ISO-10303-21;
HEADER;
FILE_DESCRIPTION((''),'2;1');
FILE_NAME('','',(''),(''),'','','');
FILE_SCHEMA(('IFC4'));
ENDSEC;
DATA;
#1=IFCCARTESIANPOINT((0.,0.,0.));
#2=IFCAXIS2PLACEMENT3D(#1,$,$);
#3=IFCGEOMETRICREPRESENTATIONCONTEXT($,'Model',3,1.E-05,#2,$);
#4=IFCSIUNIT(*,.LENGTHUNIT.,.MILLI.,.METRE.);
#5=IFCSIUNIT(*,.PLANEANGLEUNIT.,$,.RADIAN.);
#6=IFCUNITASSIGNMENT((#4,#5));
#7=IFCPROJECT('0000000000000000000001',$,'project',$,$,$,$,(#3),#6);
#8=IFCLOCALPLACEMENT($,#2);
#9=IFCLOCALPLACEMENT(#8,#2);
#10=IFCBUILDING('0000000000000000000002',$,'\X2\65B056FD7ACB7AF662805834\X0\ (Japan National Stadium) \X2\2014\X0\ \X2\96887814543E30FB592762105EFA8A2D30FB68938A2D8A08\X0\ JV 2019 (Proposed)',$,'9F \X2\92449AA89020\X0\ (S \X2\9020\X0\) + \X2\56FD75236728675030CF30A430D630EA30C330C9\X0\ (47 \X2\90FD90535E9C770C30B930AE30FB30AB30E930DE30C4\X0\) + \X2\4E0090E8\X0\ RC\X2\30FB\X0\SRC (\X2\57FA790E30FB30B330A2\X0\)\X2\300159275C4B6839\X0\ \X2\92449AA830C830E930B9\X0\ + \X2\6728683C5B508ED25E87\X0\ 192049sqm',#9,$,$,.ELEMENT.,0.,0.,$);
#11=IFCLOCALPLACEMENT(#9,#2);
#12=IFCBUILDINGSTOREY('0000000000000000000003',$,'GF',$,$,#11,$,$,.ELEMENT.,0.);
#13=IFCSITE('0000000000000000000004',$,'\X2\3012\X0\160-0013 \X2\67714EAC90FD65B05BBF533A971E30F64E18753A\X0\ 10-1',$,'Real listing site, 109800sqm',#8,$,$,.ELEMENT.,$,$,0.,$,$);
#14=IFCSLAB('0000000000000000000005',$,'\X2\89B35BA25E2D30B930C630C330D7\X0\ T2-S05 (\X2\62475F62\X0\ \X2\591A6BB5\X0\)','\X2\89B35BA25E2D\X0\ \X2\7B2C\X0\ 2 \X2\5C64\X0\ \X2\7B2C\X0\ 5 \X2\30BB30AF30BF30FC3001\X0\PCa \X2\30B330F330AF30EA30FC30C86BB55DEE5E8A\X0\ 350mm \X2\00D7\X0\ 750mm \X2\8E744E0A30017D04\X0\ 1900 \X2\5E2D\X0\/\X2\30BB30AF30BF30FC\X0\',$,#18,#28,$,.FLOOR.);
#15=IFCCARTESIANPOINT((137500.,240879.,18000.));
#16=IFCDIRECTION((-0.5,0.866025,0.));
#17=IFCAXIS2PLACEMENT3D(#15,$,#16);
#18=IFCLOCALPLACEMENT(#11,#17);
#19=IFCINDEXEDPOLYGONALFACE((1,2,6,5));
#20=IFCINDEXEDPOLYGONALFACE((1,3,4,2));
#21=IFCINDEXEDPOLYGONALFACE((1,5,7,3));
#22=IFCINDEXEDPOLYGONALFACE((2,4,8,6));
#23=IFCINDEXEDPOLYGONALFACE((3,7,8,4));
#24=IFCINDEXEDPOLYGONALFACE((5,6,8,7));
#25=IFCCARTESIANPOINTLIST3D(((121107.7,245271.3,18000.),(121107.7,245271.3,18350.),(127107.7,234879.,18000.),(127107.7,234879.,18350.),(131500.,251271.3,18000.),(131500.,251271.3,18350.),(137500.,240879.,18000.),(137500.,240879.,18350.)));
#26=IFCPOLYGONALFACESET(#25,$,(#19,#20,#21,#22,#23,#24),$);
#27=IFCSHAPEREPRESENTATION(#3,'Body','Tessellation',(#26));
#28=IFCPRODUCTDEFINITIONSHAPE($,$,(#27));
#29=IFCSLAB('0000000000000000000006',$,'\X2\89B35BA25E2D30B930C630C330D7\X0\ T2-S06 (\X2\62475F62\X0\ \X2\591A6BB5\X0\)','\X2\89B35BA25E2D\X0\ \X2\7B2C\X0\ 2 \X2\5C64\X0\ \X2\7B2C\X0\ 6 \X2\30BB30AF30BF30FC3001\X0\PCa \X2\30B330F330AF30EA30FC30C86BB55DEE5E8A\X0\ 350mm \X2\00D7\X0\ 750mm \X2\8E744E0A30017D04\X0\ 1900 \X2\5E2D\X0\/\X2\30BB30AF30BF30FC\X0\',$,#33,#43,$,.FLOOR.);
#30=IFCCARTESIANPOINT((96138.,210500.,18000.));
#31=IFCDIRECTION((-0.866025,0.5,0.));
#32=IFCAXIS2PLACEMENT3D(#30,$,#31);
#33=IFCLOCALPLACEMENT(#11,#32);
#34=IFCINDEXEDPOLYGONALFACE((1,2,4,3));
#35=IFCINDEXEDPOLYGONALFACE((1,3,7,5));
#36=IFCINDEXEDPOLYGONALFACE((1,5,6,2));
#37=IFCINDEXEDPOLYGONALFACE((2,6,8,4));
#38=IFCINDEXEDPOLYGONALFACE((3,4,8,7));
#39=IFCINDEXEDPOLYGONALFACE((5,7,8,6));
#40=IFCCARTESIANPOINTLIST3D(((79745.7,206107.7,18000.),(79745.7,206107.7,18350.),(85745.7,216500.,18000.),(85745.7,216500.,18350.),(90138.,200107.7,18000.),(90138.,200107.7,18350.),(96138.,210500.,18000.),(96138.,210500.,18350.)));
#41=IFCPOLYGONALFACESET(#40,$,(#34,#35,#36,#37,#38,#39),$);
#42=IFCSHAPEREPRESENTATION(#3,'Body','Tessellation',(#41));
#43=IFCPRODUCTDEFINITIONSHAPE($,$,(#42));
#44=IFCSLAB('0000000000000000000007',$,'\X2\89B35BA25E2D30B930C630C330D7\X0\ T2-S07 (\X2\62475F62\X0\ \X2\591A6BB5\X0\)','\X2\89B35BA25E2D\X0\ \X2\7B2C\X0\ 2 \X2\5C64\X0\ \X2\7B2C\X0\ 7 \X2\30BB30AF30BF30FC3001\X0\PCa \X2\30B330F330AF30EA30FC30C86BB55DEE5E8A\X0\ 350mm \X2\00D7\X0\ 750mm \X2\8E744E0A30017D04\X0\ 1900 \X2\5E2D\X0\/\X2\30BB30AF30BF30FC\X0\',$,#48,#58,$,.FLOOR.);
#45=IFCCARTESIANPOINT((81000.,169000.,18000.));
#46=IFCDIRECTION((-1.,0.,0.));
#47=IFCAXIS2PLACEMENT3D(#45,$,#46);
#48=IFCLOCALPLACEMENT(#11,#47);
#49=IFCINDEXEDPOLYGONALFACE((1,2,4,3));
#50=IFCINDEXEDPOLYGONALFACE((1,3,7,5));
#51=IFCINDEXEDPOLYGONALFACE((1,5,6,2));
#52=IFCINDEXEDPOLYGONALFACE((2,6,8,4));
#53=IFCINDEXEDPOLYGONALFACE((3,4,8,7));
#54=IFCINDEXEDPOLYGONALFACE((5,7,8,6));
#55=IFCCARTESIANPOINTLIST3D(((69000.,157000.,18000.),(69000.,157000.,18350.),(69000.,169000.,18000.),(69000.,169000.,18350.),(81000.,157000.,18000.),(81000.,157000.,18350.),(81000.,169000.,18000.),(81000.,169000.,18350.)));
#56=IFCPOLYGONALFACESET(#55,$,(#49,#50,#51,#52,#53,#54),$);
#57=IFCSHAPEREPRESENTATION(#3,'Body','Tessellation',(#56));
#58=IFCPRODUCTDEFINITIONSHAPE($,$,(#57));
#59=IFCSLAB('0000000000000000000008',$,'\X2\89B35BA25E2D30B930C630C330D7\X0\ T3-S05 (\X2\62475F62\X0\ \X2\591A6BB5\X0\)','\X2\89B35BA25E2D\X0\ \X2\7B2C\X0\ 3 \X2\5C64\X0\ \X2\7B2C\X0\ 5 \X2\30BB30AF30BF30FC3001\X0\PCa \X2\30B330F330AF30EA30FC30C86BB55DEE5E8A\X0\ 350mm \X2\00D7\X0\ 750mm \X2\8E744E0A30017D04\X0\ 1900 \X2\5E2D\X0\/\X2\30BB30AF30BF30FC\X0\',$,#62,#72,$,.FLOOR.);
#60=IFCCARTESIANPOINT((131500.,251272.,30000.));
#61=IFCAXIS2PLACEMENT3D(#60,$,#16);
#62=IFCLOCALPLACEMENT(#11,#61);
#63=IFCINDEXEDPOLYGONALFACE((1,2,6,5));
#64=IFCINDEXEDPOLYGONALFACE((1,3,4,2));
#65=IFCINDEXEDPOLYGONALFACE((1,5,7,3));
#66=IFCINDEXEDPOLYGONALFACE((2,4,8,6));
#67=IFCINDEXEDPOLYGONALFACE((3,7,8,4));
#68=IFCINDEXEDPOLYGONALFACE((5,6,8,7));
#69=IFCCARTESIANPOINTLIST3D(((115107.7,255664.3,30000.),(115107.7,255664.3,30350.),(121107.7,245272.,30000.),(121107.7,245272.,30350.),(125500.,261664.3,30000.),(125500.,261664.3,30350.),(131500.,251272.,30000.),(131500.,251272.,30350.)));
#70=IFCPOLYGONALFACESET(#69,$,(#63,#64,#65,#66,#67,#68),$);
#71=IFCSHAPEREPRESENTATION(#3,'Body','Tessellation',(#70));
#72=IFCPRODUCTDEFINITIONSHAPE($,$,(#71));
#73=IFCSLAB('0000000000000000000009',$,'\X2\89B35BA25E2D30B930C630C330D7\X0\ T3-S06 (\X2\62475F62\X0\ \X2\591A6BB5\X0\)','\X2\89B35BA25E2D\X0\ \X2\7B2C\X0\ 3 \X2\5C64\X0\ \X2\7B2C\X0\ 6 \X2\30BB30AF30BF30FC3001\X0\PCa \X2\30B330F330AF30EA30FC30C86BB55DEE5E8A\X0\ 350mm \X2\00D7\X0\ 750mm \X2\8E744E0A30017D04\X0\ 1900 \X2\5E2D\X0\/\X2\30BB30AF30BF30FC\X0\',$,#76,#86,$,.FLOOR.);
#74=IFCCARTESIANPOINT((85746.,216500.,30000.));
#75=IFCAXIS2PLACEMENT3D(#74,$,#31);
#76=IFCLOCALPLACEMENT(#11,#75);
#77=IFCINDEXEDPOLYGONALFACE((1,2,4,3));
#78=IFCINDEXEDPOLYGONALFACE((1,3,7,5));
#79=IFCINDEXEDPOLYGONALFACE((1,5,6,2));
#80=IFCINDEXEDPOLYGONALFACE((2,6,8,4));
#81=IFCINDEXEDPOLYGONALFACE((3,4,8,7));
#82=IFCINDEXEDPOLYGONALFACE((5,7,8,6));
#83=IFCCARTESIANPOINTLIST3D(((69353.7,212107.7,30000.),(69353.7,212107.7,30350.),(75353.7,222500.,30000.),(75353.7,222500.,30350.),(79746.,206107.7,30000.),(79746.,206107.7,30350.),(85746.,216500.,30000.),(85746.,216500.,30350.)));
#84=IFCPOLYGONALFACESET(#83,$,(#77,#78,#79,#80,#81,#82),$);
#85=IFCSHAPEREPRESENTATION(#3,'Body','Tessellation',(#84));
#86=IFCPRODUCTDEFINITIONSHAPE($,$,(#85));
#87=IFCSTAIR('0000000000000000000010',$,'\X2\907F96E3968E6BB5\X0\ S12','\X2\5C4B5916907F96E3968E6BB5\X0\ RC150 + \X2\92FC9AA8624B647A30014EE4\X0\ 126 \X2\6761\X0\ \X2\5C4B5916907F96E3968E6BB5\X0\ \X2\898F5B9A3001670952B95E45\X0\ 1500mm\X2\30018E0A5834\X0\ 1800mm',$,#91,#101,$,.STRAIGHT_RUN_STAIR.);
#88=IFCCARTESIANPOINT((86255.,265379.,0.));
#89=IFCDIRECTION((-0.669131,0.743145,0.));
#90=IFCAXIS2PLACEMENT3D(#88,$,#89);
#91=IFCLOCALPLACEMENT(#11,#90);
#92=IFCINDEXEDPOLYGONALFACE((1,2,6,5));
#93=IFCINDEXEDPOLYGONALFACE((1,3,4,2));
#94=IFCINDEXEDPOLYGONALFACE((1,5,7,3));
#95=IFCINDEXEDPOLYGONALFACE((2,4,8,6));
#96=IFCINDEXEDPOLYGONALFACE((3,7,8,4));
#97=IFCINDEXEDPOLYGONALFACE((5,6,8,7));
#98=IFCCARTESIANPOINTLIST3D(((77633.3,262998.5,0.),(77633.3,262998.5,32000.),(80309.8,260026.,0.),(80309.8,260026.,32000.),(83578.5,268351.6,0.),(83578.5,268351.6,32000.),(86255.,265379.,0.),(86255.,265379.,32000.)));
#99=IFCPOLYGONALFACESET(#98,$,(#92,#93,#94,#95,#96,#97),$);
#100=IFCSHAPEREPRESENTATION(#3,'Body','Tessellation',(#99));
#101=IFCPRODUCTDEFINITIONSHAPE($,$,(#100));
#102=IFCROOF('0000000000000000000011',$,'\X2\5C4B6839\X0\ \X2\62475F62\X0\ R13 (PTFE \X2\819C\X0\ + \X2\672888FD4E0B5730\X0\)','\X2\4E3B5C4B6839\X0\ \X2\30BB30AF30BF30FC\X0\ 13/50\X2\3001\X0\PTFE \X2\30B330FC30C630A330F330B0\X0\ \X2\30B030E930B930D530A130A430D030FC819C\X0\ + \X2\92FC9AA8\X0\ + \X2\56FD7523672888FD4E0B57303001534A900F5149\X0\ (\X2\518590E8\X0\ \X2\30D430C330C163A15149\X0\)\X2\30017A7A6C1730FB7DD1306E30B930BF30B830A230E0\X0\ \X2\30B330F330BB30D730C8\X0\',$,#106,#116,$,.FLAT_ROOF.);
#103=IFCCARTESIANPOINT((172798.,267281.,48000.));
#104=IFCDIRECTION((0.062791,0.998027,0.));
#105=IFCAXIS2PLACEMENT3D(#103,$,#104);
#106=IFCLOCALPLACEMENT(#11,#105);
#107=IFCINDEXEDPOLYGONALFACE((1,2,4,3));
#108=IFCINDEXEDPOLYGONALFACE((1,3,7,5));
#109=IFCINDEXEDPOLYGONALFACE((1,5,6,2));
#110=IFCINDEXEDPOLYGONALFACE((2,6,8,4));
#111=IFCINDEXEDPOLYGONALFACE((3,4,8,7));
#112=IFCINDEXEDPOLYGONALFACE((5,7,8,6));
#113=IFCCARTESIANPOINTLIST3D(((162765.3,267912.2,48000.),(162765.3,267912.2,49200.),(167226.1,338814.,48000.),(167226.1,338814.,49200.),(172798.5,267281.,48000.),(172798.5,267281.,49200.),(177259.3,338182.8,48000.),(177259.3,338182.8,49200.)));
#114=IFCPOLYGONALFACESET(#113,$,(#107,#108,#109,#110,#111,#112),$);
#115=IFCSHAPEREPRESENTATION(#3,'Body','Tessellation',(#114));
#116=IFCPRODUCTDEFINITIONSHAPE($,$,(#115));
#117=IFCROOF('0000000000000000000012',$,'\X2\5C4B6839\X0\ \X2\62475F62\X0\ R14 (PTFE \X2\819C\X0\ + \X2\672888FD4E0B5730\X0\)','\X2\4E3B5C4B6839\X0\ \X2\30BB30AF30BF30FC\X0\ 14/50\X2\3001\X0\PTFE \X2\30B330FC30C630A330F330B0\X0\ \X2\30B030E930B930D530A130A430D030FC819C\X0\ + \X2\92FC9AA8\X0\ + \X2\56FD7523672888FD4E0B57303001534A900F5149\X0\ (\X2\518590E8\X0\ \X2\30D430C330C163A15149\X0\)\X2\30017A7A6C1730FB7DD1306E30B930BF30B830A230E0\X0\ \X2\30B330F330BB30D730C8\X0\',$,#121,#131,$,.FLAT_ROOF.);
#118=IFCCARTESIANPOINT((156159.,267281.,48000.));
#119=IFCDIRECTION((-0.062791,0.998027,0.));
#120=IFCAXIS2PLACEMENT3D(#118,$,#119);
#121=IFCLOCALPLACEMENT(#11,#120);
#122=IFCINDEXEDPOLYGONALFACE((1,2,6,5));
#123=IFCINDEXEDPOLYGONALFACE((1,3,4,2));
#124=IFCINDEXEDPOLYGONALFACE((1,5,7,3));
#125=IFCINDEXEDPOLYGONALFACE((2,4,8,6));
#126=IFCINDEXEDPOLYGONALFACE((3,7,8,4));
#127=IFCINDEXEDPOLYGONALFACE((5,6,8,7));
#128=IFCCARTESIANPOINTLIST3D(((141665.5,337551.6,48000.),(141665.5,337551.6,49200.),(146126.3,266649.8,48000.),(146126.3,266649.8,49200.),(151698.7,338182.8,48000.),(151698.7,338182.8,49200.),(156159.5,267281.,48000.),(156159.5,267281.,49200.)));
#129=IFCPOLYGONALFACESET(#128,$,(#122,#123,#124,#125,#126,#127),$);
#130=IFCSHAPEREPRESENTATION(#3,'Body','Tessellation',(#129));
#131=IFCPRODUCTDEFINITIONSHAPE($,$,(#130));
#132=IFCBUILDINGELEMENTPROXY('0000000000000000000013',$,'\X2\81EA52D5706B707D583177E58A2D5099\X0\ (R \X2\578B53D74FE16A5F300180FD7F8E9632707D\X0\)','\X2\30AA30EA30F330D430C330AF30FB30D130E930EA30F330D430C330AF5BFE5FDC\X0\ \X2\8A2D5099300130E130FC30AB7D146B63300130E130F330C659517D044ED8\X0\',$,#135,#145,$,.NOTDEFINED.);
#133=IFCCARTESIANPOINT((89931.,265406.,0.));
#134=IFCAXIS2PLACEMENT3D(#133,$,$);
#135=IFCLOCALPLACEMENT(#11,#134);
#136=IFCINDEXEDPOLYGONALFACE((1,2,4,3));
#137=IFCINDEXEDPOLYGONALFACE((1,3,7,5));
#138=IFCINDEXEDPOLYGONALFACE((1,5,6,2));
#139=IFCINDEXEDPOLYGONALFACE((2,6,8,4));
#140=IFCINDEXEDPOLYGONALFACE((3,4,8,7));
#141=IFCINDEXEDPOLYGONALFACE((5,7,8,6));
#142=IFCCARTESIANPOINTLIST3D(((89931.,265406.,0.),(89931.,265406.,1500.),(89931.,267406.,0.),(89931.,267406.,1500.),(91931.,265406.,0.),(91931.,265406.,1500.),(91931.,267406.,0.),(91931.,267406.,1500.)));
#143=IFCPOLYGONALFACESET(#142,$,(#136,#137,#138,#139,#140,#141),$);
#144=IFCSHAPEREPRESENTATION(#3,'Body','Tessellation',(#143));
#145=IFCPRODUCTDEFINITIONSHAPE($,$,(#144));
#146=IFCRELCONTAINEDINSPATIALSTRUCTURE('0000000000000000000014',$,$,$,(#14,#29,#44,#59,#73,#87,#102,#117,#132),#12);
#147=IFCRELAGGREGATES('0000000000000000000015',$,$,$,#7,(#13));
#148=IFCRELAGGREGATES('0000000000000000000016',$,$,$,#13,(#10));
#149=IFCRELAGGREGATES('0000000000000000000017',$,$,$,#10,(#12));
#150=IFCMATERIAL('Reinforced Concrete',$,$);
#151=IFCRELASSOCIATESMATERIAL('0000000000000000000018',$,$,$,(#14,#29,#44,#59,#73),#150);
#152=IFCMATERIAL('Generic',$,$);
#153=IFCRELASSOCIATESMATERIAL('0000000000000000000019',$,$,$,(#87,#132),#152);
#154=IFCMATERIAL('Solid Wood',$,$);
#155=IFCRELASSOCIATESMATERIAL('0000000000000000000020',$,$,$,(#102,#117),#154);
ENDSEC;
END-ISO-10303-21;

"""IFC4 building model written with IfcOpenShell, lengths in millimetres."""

from ifc_helpers import new_model, si_unit, frame, frame_2d, origin, place, context, project, spatial, rectangle, extrude, material, element, save


model = new_model("IFC4")

# Units and contexts
model_context = context("Model", 3, precision=1e-05, world=origin())
ifc_project = project(units=[si_unit("LENGTHUNIT", "METRE", prefix="MILLI"), si_unit("PLANEANGLEUNIT", "RADIAN")], contexts=[model_context])

# Site, building, storey
site_placement = place(None, origin())
site = spatial("IfcSite", under=ifc_project, at=site_placement, Name="〒160-0013 東京都新宿区霞ヶ丘町 10-1", ObjectType="Real listing site, 109800sqm", CompositionType="ELEMENT", RefElevation=0.0)
building_placement = place(site_placement, origin())
building = spatial("IfcBuilding", under=site, at=building_placement, Name="新国立競技場 (Japan National Stadium) — 隈研吾・大成建設・梓設計 JV 2019 (Proposed)", ObjectType="9F 鉄骨造 (S 造) + 国産木材ハイブリッド (47 都道府県スギ・カラマツ) + 一部 RC・SRC (基礎・コア)、大屋根 鉄骨トラス + 木格子軒庇 192049sqm", CompositionType="ELEMENT", ElevationOfRefHeight=0.0, ElevationOfTerrain=0.0)
storey_placement = place(building_placement, origin())
storey = spatial("IfcBuildingStorey", under=building, at=storey_placement, Name="GF", CompositionType="ELEMENT", Elevation=0.0)

# Shared definitions
ifc_material_1 = material(Name="Reinforced Concrete")
ifc_material_2 = material(Name="Generic")

# Shared definitions
ifc_material_3 = material(Name="Solid Wood")

# Slabs
slab_1_placement = place(storey_placement, frame((137500.0, 240879.0, 18000.0), x_axis=(-0.5, 0.866025, 0.0)))
element("IfcSlab", 1, at=slab_1_placement, inside=storey, material=ifc_material_1, Name="観客席ステップ T2-S05 (扇形 多段)", Description="観客席 第 2 層 第 5 セクター、PCa コンクリート段差床 350mm × 750mm 蹴上、約 1900 席/セクター", PredefinedType="FLOOR", context=model_context, shape_type="SweptSolid", body=[
    extrude(rectangle(XDim=12000.0, YDim=12000.0, at=frame_2d((6000.0, 6000.0))), frame((137500.0, 240879.0, 18000.0), x_axis=(-0.5, 0.866025, 0.0)), (0.0, 0.0, 1.0), 350.0),
])
slab_2_placement = place(storey_placement, frame((96138.0, 210500.0, 18000.0), x_axis=(-0.866025, 0.5, 0.0)))
element("IfcSlab", 2, at=slab_2_placement, inside=storey, material=ifc_material_1, Name="観客席ステップ T2-S06 (扇形 多段)", Description="観客席 第 2 層 第 6 セクター、PCa コンクリート段差床 350mm × 750mm 蹴上、約 1900 席/セクター", PredefinedType="FLOOR", context=model_context, shape_type="SweptSolid", body=[
    extrude(rectangle(XDim=12000.0, YDim=12000.0, at=frame_2d((6000.0, 6000.0))), frame((96138.0, 210500.0, 18000.0), x_axis=(-0.866025, 0.5, 0.0)), (0.0, 0.0, 1.0), 350.0),
])
slab_3_placement = place(storey_placement, frame((81000.0, 169000.0, 18000.0), x_axis=(-1.0, 0.0, 0.0)))
element("IfcSlab", 3, at=slab_3_placement, inside=storey, material=ifc_material_1, Name="観客席ステップ T2-S07 (扇形 多段)", Description="観客席 第 2 層 第 7 セクター、PCa コンクリート段差床 350mm × 750mm 蹴上、約 1900 席/セクター", PredefinedType="FLOOR", context=model_context, shape_type="SweptSolid", body=[
    extrude(rectangle(XDim=12000.0, YDim=12000.0, at=frame_2d((6000.0, 6000.0))), frame((81000.0, 169000.0, 18000.0), x_axis=(-1.0, 0.0, 0.0)), (0.0, 0.0, 1.0), 350.0),
])
slab_4_placement = place(storey_placement, frame((131500.0, 251272.0, 30000.0), x_axis=(-0.5, 0.866025, 0.0)))
element("IfcSlab", 4, at=slab_4_placement, inside=storey, material=ifc_material_1, Name="観客席ステップ T3-S05 (扇形 多段)", Description="観客席 第 3 層 第 5 セクター、PCa コンクリート段差床 350mm × 750mm 蹴上、約 1900 席/セクター", PredefinedType="FLOOR", context=model_context, shape_type="SweptSolid", body=[
    extrude(rectangle(XDim=12000.0, YDim=12000.0, at=frame_2d((6000.0, 6000.0))), frame((131500.0, 251272.0, 30000.0), x_axis=(-0.5, 0.866025, 0.0)), (0.0, 0.0, 1.0), 350.0),
])
slab_5_placement = place(storey_placement, frame((85746.0, 216500.0, 30000.0), x_axis=(-0.866025, 0.5, 0.0)))
element("IfcSlab", 5, at=slab_5_placement, inside=storey, material=ifc_material_1, Name="観客席ステップ T3-S06 (扇形 多段)", Description="観客席 第 3 層 第 6 セクター、PCa コンクリート段差床 350mm × 750mm 蹴上、約 1900 席/セクター", PredefinedType="FLOOR", context=model_context, shape_type="SweptSolid", body=[
    extrude(rectangle(XDim=12000.0, YDim=12000.0, at=frame_2d((6000.0, 6000.0))), frame((85746.0, 216500.0, 30000.0), x_axis=(-0.866025, 0.5, 0.0)), (0.0, 0.0, 1.0), 350.0),
])

# Stair
stair_placement = place(storey_placement, frame((86255.0, 265379.0, 0.0), x_axis=(-0.669131, 0.743145, 0.0)))
element("IfcStair", 6, at=stair_placement, inside=storey, material=ifc_material_2, Name="避難階段 S12", Description="屋外避難階段 RC150 + 鋼骨手摺、令 126 条 屋外避難階段 規定、有効幅 1500mm、踊場 1800mm", PredefinedType="STRAIGHT_RUN_STAIR", context=model_context, shape_type="SweptSolid", body=[
    extrude(rectangle(XDim=4000.0, YDim=8000.0, at=frame_2d((2000.0, 4000.0))), frame((86255.0, 265379.0, 0.0), x_axis=(-0.669131, 0.743145, 0.0)), (0.0, 0.0, 1.0), 32000.0),
])

# Roofs
roof_1_placement = place(storey_placement, frame((172798.0, 267281.0, 48000.0), x_axis=(0.062791, 0.998027, 0.0)))
element("IfcRoof", 7, at=roof_1_placement, inside=storey, material=ifc_material_3, Name="屋根 扇形 R13 (PTFE 膜 + 木製下地)", Description="主屋根 セクター 13/50、PTFE コーティング グラスファイバー膜 + 鋼骨 + 国産木製下地、半透光 (内部 ピッチ採光)、空気・緑のスタジアム コンセプト", PredefinedType="FLAT_ROOF", context=model_context, shape_type="SweptSolid", body=[
    extrude(rectangle(XDim=71042.0, YDim=10053.0, at=frame_2d((35521.0, 5026.0))), frame((172798.0, 267281.0, 48000.0), x_axis=(0.062791, 0.998027, 0.0)), (0.0, 0.0, 1.0), 1200.0),
])
roof_2_placement = place(storey_placement, frame((156159.0, 267281.0, 48000.0), x_axis=(-0.062791, 0.998027, 0.0)))
element("IfcRoof", 8, at=roof_2_placement, inside=storey, material=ifc_material_3, Name="屋根 扇形 R14 (PTFE 膜 + 木製下地)", Description="主屋根 セクター 14/50、PTFE コーティング グラスファイバー膜 + 鋼骨 + 国産木製下地、半透光 (内部 ピッチ採光)、空気・緑のスタジアム コンセプト", PredefinedType="FLAT_ROOF", context=model_context, shape_type="SweptSolid", body=[
    extrude(rectangle(XDim=71042.0, YDim=10053.0, at=frame_2d((35521.0, 5026.0))), frame((156159.0, 267281.0, 48000.0), x_axis=(-0.062791, 0.998027, 0.0)), (0.0, 0.0, 1.0), 1200.0),
])

# Building element proxy
proxy_placement = place(storey_placement, frame((89931.0, 265406.0, 0.0)))
element("IfcBuildingElementProxy", 9, at=proxy_placement, inside=storey, material=ifc_material_2, Name="自動火災報知設備 (R 型受信機、能美防災)", Description="オリンピック・パラリンピック対応 設備、メーカ純正、メンテ契約付", PredefinedType="NOTDEFINED", context=model_context, shape_type="SweptSolid", body=[
    extrude(rectangle(XDim=2000.0, YDim=2000.0, at=frame_2d((1000.0, 1000.0))), frame((89931.0, 265406.0, 0.0)), (0.0, 0.0, 1.0), 1500.0),
])

save(model, "model.ifc")
